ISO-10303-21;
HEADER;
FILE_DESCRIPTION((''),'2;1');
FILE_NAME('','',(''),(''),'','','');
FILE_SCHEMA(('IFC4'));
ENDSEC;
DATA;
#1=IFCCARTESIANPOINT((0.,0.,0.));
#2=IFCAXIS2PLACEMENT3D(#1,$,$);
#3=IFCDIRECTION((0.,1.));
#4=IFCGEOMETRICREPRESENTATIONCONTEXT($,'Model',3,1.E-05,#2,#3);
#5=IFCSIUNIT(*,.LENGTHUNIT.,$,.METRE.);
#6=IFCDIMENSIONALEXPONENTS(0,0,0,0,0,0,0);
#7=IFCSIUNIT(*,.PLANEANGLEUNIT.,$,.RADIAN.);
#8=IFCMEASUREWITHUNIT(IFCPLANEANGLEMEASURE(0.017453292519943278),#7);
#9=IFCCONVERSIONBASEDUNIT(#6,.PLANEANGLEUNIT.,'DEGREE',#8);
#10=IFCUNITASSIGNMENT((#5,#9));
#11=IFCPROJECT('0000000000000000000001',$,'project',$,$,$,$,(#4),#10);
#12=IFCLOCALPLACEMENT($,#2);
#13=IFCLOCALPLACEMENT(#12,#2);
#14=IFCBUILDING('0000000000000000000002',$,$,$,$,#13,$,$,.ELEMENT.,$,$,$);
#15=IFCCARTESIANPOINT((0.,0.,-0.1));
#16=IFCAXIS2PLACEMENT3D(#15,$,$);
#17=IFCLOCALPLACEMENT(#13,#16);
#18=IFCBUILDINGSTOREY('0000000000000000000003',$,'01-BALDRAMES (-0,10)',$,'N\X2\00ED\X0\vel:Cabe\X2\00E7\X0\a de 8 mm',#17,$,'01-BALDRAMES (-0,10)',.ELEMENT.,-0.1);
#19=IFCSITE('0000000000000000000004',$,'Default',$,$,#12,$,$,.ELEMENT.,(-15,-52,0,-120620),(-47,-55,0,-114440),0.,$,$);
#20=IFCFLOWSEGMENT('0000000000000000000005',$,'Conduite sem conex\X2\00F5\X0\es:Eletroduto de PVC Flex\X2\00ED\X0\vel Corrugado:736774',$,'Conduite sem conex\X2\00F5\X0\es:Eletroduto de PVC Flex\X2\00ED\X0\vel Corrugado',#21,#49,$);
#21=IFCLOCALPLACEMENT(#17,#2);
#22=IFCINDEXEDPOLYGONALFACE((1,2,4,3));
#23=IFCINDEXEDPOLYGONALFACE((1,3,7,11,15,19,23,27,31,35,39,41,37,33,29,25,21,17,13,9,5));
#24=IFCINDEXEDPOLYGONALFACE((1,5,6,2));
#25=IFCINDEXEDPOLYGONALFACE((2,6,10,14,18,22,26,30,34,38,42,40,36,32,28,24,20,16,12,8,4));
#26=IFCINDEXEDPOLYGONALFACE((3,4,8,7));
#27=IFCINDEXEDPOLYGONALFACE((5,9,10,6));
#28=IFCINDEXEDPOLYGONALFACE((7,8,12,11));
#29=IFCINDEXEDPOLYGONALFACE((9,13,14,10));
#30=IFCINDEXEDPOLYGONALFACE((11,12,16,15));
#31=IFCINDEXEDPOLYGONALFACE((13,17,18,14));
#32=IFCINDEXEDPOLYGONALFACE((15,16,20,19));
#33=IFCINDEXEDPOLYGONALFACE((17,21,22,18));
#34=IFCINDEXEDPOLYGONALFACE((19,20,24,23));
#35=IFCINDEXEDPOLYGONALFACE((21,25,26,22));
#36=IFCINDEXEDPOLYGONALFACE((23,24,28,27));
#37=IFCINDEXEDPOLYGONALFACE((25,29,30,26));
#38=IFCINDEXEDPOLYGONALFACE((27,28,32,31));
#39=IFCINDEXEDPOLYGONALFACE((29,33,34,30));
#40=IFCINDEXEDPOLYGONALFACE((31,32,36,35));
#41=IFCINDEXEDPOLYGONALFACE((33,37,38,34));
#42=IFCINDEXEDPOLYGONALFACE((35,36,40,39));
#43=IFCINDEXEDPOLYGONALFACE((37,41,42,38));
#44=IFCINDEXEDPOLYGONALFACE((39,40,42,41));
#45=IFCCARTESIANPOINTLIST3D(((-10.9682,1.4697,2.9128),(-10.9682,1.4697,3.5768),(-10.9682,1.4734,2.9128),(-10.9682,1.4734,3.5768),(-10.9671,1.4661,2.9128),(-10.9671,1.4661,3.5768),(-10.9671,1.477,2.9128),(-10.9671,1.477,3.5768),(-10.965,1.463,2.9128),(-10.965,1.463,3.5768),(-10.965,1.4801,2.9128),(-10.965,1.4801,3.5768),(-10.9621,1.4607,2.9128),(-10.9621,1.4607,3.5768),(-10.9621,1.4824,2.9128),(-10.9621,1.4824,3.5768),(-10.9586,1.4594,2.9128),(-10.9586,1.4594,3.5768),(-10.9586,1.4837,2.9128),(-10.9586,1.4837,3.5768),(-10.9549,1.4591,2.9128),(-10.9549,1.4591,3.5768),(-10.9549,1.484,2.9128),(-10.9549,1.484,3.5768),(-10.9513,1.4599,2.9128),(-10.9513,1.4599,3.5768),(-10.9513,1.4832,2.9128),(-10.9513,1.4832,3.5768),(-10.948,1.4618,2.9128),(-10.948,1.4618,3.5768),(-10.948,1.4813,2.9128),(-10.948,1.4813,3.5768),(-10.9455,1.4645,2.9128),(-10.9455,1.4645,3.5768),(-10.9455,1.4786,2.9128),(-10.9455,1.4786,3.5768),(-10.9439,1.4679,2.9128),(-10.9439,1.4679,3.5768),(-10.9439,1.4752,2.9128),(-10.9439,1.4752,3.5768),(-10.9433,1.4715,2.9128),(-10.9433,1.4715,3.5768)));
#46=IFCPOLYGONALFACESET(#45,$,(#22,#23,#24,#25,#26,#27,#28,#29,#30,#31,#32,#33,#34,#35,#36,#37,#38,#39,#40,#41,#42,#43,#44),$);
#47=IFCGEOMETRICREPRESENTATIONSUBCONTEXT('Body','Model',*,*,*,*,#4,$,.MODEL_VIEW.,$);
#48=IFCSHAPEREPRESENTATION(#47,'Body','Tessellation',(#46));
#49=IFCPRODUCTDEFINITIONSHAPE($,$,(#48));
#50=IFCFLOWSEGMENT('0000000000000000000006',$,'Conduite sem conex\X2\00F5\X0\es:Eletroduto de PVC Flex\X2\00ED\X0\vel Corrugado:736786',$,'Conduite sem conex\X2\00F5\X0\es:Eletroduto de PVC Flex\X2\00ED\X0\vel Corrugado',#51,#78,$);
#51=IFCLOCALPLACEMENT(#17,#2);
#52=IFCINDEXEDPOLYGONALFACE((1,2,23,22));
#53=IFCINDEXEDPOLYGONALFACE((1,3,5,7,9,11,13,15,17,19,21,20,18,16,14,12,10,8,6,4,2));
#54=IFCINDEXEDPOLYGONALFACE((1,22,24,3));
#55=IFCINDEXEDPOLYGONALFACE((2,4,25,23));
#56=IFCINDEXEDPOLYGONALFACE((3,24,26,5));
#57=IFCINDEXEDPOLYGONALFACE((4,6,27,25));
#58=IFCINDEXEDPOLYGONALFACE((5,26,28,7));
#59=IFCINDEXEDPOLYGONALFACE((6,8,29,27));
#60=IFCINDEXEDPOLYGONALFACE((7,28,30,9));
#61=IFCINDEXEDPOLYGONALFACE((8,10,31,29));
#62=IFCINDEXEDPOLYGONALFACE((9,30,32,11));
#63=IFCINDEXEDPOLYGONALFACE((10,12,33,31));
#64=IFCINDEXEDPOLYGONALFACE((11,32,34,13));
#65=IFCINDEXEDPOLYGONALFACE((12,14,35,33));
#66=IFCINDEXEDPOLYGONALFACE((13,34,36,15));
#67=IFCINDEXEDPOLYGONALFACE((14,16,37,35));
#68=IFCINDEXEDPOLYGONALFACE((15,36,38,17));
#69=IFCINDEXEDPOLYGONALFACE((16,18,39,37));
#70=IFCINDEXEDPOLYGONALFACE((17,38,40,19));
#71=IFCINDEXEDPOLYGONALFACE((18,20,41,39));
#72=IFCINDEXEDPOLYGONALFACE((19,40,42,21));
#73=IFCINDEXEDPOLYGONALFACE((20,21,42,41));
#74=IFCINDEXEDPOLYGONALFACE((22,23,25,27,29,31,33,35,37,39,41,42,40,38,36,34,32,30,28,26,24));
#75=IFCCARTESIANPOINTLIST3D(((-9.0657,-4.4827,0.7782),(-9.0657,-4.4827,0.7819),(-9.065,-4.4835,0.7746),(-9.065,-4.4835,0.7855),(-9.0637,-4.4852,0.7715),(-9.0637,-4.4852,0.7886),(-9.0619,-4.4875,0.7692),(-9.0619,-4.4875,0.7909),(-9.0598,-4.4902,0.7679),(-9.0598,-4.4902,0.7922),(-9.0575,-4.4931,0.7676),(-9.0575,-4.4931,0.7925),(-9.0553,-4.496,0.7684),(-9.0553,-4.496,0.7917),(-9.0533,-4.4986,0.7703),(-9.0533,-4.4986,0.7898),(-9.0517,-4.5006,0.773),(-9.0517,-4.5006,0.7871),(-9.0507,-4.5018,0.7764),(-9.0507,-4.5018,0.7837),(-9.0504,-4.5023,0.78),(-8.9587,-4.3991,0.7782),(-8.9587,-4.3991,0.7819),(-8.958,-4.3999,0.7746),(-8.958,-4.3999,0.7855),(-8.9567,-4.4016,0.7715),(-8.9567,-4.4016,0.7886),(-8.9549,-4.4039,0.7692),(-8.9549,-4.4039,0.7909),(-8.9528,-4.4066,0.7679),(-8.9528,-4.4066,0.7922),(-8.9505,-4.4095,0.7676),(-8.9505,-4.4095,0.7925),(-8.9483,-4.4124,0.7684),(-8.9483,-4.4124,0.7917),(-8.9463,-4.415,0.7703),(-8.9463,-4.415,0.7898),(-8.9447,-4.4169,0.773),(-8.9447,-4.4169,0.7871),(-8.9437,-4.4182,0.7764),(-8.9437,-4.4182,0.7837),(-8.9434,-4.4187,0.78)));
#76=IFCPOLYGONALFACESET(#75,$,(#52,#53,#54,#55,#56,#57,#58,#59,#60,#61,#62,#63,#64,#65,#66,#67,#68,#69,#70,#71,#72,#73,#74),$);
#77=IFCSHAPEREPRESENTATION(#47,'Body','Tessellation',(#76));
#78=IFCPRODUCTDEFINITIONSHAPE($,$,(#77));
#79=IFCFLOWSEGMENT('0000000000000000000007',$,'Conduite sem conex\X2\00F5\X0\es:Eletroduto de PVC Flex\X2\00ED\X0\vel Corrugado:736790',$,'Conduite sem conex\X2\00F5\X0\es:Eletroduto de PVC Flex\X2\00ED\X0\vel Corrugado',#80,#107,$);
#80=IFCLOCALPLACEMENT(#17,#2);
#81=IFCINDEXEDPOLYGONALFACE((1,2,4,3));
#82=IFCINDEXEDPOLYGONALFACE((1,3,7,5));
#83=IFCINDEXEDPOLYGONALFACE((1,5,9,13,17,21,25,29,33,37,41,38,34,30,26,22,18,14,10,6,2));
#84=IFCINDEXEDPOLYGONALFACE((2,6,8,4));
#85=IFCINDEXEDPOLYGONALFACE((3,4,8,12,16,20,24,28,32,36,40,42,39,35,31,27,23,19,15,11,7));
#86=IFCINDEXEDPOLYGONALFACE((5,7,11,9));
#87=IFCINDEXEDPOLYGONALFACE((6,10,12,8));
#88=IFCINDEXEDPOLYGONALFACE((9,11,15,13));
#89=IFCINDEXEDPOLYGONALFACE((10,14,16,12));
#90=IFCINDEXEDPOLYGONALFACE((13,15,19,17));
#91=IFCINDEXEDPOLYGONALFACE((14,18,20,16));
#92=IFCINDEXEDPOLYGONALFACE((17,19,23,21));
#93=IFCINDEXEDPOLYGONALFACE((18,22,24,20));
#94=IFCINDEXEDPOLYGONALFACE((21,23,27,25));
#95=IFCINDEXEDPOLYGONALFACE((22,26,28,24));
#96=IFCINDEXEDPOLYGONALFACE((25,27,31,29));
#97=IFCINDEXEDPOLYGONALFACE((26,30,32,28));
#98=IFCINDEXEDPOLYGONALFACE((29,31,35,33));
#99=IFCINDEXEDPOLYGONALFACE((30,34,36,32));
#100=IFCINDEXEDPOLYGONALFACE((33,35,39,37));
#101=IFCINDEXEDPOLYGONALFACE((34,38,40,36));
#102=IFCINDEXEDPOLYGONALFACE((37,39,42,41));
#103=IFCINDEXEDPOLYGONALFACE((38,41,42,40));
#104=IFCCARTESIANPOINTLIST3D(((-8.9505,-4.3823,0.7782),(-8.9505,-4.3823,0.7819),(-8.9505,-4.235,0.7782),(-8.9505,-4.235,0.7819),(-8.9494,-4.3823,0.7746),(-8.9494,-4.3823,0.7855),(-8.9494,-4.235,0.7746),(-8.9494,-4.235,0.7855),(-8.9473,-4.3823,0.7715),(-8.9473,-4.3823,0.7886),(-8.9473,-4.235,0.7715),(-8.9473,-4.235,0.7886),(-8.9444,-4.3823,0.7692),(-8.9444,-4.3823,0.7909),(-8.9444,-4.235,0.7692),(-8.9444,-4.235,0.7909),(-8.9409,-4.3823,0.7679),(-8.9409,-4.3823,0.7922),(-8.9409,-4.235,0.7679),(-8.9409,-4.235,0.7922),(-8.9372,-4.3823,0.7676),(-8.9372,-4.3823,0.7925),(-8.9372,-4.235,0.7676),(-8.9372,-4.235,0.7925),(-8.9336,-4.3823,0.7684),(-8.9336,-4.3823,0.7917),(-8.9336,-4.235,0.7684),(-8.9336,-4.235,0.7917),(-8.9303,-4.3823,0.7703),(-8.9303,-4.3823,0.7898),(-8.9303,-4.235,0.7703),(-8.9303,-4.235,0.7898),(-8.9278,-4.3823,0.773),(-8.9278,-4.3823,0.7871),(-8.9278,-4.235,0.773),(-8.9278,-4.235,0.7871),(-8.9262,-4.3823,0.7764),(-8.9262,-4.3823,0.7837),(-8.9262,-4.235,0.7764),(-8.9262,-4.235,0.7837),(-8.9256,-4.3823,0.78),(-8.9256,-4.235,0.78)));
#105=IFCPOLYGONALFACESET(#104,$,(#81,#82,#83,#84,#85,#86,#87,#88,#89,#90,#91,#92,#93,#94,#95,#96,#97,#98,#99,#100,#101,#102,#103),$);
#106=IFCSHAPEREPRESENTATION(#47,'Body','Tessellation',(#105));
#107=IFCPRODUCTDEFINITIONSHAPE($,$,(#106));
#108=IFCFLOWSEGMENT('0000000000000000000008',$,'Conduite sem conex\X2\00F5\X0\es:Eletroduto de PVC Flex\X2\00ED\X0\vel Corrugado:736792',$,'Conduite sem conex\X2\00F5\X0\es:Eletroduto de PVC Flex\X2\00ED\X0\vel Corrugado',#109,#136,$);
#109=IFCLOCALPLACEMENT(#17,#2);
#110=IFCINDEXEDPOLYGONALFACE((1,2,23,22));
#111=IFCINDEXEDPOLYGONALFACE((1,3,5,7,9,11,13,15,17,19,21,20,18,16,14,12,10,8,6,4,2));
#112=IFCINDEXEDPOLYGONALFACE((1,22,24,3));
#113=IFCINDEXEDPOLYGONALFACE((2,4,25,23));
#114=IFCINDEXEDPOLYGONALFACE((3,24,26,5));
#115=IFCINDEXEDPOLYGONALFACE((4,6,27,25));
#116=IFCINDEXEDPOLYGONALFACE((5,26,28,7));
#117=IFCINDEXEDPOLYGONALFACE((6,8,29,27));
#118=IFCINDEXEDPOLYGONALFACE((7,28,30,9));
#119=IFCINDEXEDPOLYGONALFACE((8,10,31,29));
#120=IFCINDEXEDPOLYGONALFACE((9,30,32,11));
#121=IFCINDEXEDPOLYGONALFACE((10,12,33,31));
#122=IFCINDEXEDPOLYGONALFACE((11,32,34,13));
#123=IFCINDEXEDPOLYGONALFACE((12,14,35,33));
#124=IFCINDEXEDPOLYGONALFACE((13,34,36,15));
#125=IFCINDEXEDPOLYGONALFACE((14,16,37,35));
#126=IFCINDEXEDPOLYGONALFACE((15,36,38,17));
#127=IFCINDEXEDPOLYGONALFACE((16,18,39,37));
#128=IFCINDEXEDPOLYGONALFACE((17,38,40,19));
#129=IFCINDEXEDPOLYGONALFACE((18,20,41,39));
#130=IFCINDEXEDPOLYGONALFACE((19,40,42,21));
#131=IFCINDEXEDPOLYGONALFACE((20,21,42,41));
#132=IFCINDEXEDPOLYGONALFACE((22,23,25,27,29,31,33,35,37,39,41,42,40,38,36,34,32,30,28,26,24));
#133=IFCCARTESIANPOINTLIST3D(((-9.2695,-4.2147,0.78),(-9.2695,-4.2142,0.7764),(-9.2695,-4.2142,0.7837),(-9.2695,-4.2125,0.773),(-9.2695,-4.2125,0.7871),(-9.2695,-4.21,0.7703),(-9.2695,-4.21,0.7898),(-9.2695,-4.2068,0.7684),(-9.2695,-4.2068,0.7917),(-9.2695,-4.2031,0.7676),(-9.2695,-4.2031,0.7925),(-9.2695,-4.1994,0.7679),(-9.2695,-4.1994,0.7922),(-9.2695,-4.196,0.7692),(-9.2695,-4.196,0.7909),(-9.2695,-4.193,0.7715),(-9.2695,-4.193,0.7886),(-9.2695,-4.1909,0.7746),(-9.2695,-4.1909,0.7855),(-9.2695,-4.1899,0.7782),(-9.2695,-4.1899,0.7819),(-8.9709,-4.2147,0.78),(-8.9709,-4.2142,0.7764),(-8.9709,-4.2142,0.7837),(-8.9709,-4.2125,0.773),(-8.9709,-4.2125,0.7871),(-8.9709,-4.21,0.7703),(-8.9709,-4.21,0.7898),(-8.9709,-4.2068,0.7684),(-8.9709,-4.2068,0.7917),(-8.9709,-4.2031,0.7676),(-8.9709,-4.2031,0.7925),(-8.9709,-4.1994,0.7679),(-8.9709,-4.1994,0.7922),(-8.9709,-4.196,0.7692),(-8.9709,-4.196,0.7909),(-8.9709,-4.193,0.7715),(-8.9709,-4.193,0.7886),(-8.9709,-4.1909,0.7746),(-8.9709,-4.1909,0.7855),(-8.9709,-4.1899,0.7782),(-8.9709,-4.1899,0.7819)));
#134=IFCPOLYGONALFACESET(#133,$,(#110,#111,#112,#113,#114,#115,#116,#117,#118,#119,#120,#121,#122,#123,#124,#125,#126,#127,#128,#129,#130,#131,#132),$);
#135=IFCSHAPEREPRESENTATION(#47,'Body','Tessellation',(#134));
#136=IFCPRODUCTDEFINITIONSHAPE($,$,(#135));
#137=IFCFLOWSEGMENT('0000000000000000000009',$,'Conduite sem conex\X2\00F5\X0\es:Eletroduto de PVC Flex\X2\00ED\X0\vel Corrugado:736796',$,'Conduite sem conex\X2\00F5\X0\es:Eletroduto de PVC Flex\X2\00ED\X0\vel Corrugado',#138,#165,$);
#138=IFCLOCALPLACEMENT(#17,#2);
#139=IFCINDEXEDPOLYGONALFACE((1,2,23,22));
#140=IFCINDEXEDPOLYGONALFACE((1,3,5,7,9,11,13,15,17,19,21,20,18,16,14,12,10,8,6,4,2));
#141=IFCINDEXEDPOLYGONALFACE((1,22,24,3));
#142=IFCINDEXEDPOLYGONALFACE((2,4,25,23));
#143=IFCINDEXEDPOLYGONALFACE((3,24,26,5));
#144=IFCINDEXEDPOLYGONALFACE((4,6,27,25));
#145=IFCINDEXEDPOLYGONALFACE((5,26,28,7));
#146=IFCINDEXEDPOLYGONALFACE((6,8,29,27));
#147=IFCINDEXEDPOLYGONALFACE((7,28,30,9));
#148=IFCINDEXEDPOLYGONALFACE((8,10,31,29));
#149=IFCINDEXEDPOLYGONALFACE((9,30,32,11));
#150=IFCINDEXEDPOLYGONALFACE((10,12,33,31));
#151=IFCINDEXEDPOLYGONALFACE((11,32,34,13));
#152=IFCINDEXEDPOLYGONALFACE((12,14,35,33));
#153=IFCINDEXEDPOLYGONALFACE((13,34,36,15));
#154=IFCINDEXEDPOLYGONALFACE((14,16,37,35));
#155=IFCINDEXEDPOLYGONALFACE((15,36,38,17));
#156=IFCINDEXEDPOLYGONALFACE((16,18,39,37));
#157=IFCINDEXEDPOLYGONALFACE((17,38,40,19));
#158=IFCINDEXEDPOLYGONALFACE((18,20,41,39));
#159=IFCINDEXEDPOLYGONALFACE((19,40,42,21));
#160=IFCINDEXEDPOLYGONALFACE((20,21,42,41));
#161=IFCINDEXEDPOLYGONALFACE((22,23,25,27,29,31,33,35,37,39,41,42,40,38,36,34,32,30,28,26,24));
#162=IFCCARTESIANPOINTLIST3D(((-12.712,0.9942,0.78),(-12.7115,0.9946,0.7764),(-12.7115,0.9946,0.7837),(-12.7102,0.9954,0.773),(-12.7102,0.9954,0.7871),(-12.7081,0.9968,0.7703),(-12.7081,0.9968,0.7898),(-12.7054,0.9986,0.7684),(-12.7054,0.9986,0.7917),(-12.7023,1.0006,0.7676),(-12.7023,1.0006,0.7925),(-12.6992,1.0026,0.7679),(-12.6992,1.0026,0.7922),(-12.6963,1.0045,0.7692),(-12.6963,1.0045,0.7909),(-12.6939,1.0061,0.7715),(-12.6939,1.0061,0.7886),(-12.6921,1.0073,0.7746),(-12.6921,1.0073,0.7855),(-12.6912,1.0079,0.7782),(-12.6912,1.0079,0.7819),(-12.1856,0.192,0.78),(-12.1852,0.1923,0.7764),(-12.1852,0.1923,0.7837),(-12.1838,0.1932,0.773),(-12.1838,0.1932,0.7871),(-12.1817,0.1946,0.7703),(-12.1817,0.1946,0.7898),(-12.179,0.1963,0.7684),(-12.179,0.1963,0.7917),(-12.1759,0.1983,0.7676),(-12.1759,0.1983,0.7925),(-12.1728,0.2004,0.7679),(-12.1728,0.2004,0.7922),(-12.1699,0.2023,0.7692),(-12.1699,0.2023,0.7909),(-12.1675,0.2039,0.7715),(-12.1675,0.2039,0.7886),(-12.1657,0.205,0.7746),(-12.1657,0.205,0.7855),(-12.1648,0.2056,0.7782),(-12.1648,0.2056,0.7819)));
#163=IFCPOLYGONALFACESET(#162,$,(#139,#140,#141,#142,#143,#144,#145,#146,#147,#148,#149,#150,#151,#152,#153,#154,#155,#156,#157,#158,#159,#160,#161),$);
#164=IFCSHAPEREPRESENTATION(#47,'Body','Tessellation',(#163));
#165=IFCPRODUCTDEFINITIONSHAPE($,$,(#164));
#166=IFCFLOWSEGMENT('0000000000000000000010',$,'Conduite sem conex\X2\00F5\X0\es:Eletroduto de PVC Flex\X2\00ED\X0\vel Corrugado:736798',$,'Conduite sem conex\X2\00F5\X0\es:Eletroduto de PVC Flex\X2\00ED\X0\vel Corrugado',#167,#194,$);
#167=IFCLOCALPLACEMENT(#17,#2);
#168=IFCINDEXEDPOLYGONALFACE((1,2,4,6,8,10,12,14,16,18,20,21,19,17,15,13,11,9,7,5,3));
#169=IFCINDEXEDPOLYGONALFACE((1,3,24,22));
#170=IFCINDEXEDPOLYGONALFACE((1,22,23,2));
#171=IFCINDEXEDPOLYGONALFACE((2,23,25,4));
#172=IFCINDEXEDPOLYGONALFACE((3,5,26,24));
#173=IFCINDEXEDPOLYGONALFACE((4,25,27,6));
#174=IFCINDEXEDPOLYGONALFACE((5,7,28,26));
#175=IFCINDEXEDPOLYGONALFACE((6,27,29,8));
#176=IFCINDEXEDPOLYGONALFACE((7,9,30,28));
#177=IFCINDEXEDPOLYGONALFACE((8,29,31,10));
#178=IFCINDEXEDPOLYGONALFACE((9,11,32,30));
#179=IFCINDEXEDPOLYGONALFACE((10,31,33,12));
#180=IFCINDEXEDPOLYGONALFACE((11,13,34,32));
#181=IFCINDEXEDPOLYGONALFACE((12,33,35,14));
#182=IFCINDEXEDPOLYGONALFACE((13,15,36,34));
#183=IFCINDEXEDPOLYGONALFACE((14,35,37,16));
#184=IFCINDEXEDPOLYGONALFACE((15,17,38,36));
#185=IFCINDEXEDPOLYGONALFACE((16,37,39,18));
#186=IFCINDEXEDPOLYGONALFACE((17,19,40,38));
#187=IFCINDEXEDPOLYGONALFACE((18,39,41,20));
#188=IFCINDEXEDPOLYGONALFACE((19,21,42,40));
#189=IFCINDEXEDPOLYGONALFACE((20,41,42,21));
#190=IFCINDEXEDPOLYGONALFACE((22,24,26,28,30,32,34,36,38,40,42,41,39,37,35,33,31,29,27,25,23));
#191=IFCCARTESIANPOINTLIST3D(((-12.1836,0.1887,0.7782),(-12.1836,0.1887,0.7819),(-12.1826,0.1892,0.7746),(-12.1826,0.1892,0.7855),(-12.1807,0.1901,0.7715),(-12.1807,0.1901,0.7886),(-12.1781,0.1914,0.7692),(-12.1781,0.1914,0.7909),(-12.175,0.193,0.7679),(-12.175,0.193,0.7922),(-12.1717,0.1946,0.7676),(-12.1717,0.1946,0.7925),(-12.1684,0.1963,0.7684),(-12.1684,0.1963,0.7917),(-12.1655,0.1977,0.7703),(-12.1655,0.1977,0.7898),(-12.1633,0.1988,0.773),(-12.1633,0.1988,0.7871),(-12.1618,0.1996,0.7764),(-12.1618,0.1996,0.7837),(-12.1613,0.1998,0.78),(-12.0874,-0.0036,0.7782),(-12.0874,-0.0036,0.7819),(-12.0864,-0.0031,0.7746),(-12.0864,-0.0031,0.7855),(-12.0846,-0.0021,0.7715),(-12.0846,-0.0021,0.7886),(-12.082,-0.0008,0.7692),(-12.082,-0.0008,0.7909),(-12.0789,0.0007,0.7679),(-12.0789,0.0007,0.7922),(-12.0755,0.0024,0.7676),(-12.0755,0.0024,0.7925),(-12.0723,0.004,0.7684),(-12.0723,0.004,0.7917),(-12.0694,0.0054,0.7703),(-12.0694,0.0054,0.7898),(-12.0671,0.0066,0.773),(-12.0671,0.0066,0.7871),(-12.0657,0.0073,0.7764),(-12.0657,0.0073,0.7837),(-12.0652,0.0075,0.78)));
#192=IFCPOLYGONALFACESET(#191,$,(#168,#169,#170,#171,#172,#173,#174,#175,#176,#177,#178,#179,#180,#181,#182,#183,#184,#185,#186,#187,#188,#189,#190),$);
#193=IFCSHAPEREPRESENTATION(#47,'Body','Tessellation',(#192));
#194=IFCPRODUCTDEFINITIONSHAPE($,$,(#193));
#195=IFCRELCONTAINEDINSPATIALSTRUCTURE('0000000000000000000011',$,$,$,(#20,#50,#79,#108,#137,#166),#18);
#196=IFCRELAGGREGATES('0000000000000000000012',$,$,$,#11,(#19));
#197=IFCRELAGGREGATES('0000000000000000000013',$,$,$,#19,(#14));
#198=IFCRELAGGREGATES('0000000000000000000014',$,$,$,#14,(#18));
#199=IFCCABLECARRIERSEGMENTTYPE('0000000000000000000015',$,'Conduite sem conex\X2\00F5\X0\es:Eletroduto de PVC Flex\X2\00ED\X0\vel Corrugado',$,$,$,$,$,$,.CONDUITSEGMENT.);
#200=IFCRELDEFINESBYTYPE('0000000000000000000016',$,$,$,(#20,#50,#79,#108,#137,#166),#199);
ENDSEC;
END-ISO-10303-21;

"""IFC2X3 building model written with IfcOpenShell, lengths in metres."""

from ifc_helpers import new_model, entity, si_unit, converted_unit, direction, frame, frame_2d, origin, origin_2d_with_axis, place, context, subcontext, project, spatial, circle, extrude, type_object, element, save


model = new_model("IFC2X3")

# Units and contexts
model_context = context("Model", 3, precision=1e-05, world=origin(), true_north=direction((0.0, 1.0)))
body_context = subcontext(model_context, "Body", "Model", "MODEL_VIEW")
ifc_project = project(units=[si_unit("LENGTHUNIT", "METRE"), converted_unit("PLANEANGLEUNIT", "DEGREE", entity("IfcPlaneAngleMeasure", 0.017453292519943278), si_unit("PLANEANGLEUNIT", "RADIAN"), dimensions=[0, 0, 0, 0, 0, 0, 0])], contexts=[model_context])

# Site, building, storey
site_placement = place(None, origin())
site = spatial("IfcSite", under=ifc_project, at=site_placement, Name="Default", CompositionType="ELEMENT", RefLatitude=(-15, -52, 0, -120620), RefLongitude=(-47, -55, 0, -114440), RefElevation=0.0)
building_placement = place(site_placement, origin())
building = spatial("IfcBuilding", under=site, at=building_placement, CompositionType="ELEMENT")
storey_placement = place(building_placement, frame((0.0, 0.0, -0.1)))
storey = spatial("IfcBuildingStorey", under=building, at=storey_placement, Name="01-BALDRAMES (-0,10)", ObjectType="Nível:Cabeça de 8 mm", LongName="01-BALDRAMES (-0,10)", CompositionType="ELEMENT", Elevation=-0.1)

# Flow segments
cable_carrier_segment_type = type_object("IfcCableCarrierSegmentType", Name="Conduite sem conexões:Eletroduto de PVC Flexível Corrugado", PredefinedType="CONDUITSEGMENT")
flow_segment_1_placement = place(storey_placement, origin())
element("IfcFlowSegment", 1, at=flow_segment_1_placement, inside=storey, type_object=cable_carrier_segment_type, Name="Conduite sem conexões:Eletroduto de PVC Flexível Corrugado:736774", ObjectType="Conduite sem conexões:Eletroduto de PVC Flexível Corrugado", context=body_context, shape_type="SweptSolid", body=[
    extrude(circle(Radius=0.0125, at=frame_2d((0.0, 0.0), x_axis=(1.0, 0.0))), frame((-10.9558, 1.4715, 2.9128)), (0.0, 0.0, 1.0), 0.6639),
])
flow_segment_2_placement = place(storey_placement, origin())
element("IfcFlowSegment", 2, at=flow_segment_2_placement, inside=storey, type_object=cable_carrier_segment_type, Name="Conduite sem conexões:Eletroduto de PVC Flexível Corrugado:736786", ObjectType="Conduite sem conexões:Eletroduto de PVC Flexível Corrugado", context=body_context, shape_type="SweptSolid", body=[
    extrude(circle(Radius=0.0125, at=frame_2d((0.0, 0.0), x_axis=(1.0, 0.0))), frame((-9.0581, -4.4924, 0.78), z_axis=(0.788011, 0.615661, 0.0), x_axis=(0.615661, -0.788011, 0.0)), (0.0, 0.0, 1.0), 0.1358),
])
flow_segment_3_placement = place(storey_placement, origin())
element("IfcFlowSegment", 3, at=flow_segment_3_placement, inside=storey, type_object=cable_carrier_segment_type, Name="Conduite sem conexões:Eletroduto de PVC Flexível Corrugado:736790", ObjectType="Conduite sem conexões:Eletroduto de PVC Flexível Corrugado", context=body_context, shape_type="SweptSolid", body=[
    extrude(circle(Radius=0.0125, at=origin_2d_with_axis()), frame((-8.9381, -4.3823, 0.78), z_axis=(0.0, 1.0, 0.0), x_axis=(1.0, 0.0, 0.0)), (0.0, 0.0, 1.0), 0.1473),
])
flow_segment_4_placement = place(storey_placement, origin())
element("IfcFlowSegment", 4, at=flow_segment_4_placement, inside=storey, type_object=cable_carrier_segment_type, Name="Conduite sem conexões:Eletroduto de PVC Flexível Corrugado:736792", ObjectType="Conduite sem conexões:Eletroduto de PVC Flexível Corrugado", context=body_context, shape_type="SweptSolid", body=[
    extrude(circle(Radius=0.0125, at=origin_2d_with_axis()), frame((-9.2695, -4.2022, 0.78), z_axis=(1.0, 0.0, 0.0), x_axis=(0.0, -1.0, 0.0)), (0.0, 0.0, 1.0), 0.2986),
])
flow_segment_5_placement = place(storey_placement, origin())
element("IfcFlowSegment", 5, at=flow_segment_5_placement, inside=storey, type_object=cable_carrier_segment_type, Name="Conduite sem conexões:Eletroduto de PVC Flexível Corrugado:736796", ObjectType="Conduite sem conexões:Eletroduto de PVC Flexível Corrugado", context=body_context, shape_type="SweptSolid", body=[
    extrude(circle(Radius=0.0125, at=frame_2d((0.0, 0.0), x_axis=(1.0, 0.0))), frame((-12.1752, 0.1988, 0.78), z_axis=(-0.548576, 0.836101, 0.0), x_axis=(-0.836101, -0.548576, 0.0)), (0.0, 0.0, 1.0), 0.9595),
])
flow_segment_6_placement = place(storey_placement, origin())
element("IfcFlowSegment", 6, at=flow_segment_6_placement, inside=storey, type_object=cable_carrier_segment_type, Name="Conduite sem conexões:Eletroduto de PVC Flexível Corrugado:736798", ObjectType="Conduite sem conexões:Eletroduto de PVC Flexível Corrugado", context=body_context, shape_type="SweptSolid", body=[
    extrude(circle(Radius=0.0125, at=frame_2d((0.0, 0.0), x_axis=(1.0, 0.0))), frame((-12.1725, 0.1942, 0.78), z_axis=(0.447189, -0.89444, 0.0), x_axis=(0.89444, 0.447189, 0.0)), (0.0, 0.0, 1.0), 0.215),
])

save(model, "model.ifc")
